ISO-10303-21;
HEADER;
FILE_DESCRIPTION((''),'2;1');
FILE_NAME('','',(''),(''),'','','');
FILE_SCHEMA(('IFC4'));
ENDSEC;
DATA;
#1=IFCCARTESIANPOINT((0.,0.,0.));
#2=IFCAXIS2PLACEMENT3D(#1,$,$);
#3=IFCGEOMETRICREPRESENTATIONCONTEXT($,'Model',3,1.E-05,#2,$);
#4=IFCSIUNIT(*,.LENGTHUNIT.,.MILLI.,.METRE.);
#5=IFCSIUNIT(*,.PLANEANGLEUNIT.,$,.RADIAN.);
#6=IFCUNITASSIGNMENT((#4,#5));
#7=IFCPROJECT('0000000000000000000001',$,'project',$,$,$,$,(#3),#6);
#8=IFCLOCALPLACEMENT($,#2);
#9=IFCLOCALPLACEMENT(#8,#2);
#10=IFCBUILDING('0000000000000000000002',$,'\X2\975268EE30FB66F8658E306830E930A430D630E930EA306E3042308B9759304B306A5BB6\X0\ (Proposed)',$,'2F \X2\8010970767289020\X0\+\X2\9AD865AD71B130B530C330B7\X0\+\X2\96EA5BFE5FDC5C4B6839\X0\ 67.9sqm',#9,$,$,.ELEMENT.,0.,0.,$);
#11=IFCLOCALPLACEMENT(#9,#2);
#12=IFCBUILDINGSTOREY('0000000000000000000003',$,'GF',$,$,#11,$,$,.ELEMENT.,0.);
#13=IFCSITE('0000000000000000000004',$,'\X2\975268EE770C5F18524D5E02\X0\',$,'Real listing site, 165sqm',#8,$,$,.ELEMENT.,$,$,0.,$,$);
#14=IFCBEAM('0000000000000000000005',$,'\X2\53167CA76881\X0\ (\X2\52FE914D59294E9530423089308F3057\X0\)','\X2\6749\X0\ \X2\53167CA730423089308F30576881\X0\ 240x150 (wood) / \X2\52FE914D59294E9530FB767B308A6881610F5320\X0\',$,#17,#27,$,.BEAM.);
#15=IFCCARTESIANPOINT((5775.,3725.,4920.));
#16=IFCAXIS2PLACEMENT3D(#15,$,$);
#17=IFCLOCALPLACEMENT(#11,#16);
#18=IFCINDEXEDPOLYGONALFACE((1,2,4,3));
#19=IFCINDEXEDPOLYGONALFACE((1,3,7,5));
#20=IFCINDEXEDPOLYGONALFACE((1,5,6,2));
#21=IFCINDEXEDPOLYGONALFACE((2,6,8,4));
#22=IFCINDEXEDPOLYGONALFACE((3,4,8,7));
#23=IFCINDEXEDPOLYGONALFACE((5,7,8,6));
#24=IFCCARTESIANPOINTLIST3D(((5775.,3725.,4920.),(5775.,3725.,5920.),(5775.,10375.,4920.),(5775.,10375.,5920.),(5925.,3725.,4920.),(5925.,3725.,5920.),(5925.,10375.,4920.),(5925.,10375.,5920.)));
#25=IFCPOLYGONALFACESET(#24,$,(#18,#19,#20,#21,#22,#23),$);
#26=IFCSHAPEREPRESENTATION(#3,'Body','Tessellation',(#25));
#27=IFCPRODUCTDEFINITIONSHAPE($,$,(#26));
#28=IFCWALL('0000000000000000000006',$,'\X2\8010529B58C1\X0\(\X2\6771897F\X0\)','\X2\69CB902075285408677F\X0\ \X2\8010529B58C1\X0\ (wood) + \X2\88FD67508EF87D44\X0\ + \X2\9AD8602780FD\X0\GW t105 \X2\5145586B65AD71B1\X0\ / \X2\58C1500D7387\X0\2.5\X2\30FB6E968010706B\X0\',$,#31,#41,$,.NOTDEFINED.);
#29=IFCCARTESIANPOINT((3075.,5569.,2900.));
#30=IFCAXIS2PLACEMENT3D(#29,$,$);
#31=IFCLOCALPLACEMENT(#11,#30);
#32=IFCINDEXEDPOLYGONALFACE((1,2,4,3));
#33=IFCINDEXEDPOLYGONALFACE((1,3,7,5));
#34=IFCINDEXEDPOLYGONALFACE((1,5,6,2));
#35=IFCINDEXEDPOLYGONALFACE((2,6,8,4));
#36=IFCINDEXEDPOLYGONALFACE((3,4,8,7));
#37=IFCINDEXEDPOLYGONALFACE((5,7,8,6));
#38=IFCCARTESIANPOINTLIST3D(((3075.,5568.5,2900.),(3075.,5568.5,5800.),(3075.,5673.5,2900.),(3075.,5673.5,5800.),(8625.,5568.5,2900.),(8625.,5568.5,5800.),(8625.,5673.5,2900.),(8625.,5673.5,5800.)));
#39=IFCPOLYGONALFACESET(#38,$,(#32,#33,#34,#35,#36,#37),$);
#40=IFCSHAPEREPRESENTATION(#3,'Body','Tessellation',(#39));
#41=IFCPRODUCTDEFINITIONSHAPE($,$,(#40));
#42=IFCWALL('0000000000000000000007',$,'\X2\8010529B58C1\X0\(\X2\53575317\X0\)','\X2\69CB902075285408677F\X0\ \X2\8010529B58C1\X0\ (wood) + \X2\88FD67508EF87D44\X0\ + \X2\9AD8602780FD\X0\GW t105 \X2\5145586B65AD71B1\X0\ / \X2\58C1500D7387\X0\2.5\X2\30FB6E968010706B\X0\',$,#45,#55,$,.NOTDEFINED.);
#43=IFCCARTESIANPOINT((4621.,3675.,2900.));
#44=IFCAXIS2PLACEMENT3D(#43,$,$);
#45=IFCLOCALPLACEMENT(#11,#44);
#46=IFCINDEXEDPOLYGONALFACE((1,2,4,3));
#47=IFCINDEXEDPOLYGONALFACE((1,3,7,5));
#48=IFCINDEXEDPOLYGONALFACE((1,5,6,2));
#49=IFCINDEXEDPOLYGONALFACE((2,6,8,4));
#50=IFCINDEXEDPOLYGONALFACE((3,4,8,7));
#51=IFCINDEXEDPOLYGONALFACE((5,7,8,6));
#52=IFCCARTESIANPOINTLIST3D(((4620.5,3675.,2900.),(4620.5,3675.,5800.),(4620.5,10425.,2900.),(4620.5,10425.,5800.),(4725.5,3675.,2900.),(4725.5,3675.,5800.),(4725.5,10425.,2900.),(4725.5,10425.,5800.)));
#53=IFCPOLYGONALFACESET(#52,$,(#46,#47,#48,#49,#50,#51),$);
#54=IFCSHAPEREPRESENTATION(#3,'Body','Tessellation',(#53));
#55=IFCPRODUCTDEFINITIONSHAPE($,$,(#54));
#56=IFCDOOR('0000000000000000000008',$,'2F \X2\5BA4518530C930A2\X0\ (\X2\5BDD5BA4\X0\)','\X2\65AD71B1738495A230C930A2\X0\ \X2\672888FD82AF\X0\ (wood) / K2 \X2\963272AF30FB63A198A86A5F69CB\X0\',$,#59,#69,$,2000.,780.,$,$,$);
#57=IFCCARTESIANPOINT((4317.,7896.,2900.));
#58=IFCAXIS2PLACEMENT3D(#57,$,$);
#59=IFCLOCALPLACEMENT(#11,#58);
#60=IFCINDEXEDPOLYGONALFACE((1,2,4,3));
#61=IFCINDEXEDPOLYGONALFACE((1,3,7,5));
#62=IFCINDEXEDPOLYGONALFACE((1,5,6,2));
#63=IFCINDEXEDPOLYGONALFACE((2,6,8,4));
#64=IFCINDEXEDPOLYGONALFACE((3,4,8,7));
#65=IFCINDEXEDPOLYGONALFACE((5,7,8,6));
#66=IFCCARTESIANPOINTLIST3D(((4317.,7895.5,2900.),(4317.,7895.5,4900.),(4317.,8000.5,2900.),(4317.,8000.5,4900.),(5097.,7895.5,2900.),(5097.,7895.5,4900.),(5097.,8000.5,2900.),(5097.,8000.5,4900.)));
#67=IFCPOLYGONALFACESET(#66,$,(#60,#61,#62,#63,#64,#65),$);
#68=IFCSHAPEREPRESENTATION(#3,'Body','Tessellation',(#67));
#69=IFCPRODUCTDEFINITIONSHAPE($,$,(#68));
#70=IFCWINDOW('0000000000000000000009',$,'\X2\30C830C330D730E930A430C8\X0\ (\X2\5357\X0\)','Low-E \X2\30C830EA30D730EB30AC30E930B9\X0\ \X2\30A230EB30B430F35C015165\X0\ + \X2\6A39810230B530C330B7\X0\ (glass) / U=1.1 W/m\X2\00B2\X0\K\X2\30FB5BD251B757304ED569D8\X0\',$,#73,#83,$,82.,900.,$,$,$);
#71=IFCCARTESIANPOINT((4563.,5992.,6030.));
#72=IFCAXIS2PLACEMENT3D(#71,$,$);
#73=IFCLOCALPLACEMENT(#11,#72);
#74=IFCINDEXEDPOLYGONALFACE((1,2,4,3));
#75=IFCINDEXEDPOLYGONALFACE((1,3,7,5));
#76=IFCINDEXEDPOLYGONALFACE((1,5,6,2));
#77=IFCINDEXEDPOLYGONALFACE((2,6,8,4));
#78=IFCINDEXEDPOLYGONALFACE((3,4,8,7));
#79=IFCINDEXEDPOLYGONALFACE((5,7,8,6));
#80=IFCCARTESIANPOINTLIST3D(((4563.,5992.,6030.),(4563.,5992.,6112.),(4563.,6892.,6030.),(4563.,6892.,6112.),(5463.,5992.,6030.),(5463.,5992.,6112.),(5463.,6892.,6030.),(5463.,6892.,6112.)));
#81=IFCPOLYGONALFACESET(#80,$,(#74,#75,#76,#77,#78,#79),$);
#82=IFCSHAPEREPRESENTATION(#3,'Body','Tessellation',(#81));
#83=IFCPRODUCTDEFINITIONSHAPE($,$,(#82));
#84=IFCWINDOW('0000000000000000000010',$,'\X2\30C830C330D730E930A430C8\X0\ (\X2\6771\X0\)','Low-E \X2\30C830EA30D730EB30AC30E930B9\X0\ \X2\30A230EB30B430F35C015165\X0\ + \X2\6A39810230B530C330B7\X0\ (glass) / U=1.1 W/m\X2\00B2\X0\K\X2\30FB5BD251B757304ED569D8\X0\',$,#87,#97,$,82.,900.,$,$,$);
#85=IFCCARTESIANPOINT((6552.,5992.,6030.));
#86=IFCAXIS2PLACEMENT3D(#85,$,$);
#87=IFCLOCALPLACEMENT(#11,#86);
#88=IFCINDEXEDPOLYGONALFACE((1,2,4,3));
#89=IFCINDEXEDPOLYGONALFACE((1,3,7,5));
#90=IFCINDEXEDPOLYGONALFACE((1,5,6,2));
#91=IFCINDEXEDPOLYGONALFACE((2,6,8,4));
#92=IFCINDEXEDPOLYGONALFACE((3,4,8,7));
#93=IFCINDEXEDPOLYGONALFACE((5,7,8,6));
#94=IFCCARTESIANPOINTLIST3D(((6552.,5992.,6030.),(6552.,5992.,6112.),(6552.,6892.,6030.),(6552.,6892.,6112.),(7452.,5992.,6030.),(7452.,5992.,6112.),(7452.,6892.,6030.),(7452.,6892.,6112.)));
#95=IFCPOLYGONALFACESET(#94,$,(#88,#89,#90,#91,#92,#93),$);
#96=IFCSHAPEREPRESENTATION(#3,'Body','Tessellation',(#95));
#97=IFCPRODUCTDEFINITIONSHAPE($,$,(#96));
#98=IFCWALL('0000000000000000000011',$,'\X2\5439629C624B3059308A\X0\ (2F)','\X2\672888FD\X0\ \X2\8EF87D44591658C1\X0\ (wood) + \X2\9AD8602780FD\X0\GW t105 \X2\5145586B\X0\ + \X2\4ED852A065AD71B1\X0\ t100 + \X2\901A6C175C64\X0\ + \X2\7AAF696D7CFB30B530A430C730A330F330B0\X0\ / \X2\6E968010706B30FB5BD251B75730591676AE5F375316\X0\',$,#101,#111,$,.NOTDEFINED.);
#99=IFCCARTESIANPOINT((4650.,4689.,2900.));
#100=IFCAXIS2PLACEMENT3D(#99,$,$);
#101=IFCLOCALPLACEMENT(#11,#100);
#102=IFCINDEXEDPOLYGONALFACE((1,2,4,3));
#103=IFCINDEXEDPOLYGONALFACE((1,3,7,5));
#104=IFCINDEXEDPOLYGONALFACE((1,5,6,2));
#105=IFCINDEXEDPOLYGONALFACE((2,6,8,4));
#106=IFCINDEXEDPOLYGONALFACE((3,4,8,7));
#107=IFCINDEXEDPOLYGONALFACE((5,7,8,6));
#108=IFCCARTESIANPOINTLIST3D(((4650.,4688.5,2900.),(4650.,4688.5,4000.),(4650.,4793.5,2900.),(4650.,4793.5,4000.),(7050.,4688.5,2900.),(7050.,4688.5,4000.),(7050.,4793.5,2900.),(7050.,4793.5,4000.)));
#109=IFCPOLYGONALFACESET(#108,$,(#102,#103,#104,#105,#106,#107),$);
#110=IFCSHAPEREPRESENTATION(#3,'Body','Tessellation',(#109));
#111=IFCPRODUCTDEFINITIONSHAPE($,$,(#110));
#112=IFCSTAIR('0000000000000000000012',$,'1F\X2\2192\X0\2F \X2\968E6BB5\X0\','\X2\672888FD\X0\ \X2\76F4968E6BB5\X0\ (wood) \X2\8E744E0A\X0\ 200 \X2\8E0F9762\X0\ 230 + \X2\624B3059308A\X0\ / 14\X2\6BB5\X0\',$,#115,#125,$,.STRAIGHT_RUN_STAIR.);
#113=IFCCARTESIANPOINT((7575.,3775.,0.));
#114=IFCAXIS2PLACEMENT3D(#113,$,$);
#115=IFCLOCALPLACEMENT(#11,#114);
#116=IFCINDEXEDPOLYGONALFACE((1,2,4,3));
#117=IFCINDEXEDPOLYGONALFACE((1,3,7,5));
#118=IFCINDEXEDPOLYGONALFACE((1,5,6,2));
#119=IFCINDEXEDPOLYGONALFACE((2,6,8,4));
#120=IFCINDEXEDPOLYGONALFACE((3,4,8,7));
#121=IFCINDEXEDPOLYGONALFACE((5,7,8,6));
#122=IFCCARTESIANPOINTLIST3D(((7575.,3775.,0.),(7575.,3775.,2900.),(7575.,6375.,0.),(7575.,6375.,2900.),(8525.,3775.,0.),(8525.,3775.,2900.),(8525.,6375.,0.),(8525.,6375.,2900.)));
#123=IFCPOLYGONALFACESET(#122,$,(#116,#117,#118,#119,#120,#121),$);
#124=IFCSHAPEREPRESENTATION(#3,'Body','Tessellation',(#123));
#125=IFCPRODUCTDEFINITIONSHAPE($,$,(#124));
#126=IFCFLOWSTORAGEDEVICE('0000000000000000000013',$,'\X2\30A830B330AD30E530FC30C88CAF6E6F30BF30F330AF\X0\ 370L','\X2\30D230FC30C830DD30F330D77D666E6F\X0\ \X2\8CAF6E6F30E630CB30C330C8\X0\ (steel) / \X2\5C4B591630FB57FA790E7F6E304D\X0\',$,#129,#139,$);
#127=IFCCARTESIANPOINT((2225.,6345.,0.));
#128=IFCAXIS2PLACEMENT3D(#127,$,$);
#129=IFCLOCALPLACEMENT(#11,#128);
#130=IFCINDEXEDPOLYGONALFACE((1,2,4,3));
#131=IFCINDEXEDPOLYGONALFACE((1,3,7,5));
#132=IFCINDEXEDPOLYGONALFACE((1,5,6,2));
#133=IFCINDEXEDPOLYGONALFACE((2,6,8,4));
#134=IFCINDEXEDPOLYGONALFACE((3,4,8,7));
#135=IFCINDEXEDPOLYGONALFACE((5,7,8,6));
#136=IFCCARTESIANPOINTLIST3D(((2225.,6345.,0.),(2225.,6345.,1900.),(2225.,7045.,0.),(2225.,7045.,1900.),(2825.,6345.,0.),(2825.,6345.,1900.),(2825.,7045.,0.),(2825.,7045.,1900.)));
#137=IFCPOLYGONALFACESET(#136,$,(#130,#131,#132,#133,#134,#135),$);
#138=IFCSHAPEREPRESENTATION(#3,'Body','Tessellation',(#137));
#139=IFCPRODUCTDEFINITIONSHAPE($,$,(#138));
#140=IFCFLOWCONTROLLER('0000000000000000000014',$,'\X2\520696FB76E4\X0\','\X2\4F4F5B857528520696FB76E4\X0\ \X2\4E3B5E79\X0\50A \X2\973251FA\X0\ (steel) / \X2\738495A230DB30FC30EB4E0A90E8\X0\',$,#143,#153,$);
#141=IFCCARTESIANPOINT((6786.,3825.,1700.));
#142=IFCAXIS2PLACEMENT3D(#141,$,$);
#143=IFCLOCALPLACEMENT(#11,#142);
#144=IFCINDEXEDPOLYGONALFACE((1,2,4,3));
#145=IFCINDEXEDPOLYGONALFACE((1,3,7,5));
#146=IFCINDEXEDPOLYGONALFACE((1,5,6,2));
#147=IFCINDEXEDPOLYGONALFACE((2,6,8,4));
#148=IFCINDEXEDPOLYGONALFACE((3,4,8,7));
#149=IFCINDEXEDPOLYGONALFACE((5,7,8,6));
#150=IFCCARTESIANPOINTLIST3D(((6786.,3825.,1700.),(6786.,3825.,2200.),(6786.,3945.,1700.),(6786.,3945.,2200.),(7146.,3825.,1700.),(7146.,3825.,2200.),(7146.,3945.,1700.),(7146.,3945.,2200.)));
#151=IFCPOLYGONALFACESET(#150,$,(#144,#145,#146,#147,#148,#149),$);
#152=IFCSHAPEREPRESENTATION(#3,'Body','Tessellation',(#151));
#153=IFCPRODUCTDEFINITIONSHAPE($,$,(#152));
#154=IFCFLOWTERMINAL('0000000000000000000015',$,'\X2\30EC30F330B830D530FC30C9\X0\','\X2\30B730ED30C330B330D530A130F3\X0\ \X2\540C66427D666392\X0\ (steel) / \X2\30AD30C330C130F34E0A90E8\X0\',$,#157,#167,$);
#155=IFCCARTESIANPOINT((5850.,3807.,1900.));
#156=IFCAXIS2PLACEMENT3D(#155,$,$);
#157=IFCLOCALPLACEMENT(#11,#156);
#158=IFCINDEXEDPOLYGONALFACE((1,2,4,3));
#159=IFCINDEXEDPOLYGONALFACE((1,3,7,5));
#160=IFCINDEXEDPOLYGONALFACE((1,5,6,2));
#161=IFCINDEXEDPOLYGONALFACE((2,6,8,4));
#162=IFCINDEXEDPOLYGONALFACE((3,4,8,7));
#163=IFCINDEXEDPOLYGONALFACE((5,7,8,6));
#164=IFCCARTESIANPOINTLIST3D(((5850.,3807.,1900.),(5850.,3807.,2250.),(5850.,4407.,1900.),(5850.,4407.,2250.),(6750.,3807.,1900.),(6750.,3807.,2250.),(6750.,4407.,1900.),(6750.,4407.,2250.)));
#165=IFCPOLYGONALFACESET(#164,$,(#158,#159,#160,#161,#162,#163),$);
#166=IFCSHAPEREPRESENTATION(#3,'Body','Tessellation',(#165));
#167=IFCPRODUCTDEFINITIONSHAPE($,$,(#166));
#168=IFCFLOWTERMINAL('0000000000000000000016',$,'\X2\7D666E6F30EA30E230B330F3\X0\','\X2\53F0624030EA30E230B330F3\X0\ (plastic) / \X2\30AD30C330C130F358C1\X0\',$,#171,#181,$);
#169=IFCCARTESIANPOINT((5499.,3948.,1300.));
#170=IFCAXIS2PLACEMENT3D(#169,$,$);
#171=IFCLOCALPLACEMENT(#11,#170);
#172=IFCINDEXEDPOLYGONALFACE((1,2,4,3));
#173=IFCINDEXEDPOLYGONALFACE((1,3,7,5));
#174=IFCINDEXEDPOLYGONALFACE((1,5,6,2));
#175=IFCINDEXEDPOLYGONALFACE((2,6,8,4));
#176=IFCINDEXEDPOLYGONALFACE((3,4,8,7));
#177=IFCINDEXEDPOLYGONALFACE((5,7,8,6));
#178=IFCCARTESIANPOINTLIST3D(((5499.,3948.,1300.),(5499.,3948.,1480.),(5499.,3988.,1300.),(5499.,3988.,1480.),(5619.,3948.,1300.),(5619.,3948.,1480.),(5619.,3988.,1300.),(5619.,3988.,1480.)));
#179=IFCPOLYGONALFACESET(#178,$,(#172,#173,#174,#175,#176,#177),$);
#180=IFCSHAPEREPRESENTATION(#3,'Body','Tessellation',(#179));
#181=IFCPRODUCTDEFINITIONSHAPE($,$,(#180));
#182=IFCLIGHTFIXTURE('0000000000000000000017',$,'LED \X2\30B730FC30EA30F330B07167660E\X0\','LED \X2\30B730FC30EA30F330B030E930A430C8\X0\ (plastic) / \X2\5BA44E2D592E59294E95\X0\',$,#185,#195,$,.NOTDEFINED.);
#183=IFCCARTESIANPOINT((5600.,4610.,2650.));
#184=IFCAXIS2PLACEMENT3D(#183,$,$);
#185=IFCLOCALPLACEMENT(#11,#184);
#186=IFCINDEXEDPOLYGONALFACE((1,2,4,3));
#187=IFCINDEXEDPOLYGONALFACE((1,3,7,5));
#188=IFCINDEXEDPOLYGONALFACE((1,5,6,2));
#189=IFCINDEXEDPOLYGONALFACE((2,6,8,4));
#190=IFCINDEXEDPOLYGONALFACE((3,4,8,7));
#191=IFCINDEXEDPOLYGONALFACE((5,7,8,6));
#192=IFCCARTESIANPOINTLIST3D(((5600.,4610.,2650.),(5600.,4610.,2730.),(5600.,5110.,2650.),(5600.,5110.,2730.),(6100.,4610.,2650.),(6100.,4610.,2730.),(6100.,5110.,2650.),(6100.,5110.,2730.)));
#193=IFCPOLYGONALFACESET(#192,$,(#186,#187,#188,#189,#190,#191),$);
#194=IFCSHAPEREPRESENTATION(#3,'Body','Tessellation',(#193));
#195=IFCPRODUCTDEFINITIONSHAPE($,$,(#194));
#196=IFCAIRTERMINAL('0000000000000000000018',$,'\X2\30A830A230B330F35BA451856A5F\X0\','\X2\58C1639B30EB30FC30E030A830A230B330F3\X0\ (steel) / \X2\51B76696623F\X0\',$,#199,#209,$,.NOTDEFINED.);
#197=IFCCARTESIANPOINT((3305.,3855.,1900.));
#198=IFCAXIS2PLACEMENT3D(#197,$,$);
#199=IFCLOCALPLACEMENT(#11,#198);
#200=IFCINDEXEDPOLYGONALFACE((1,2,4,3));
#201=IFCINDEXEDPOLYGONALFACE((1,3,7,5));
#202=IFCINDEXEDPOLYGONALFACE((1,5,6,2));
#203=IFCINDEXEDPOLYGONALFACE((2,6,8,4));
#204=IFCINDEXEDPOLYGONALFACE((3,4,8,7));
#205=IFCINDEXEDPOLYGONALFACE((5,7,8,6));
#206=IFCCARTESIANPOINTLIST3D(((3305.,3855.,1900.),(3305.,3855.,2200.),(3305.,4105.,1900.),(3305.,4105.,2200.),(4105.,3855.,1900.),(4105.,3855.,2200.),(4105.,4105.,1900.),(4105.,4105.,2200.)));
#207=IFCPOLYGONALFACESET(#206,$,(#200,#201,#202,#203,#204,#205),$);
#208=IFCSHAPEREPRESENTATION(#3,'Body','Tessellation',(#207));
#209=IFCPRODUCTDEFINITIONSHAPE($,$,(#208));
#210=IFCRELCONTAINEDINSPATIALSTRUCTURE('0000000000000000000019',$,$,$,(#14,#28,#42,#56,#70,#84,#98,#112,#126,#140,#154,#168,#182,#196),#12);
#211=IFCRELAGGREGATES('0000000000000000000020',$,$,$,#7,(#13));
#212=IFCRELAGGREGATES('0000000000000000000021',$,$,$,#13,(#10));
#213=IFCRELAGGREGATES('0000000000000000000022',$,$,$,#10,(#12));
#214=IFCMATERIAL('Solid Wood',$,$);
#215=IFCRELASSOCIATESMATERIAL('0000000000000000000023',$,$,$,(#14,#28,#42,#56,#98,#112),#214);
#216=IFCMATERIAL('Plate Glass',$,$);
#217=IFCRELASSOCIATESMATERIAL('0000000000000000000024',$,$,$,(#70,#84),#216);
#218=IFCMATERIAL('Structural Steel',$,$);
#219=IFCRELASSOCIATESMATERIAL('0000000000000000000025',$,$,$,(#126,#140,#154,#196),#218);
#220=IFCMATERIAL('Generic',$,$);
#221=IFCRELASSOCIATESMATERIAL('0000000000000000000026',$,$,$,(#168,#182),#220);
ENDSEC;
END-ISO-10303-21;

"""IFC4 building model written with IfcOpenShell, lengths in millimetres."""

from ifc_helpers import new_model, si_unit, frame, frame_2d, origin, place, context, project, spatial, rectangle, extrude, material, element, fill, save


model = new_model("IFC4")

# Units and contexts
model_context = context("Model", 3, precision=1e-05, world=origin())
ifc_project = project(units=[si_unit("LENGTHUNIT", "METRE", prefix="MILLI"), si_unit("PLANEANGLEUNIT", "RADIAN")], contexts=[model_context])

# Site, building, storey
site_placement = place(None, origin())
site = spatial("IfcSite", under=ifc_project, at=site_placement, Name="青森県弘前市", ObjectType="Real listing site, 165sqm", CompositionType="ELEMENT", RefElevation=0.0)
building_placement = place(site_placement, origin())
building = spatial("IfcBuilding", under=site, at=building_placement, Name="青森・書斎とライブラリのある静かな家 (Proposed)", ObjectType="2F 耐震木造+高断熱サッシ+雪対応屋根 67.9sqm", CompositionType="ELEMENT", ElevationOfRefHeight=0.0, ElevationOfTerrain=0.0)
storey_placement = place(building_placement, origin())
storey = spatial("IfcBuildingStorey", under=building, at=storey_placement, Name="GF", CompositionType="ELEMENT", Elevation=0.0)

# Shared definitions
ifc_material_1 = material(Name="Solid Wood")

# Beam
beam_placement = place(storey_placement, frame((5775.0, 3725.0, 4920.0)))
element("IfcBeam", 1, at=beam_placement, inside=storey, material=ifc_material_1, Name="化粧梁 (勾配天井あらわし)", Description="杉 化粧あらわし梁 240x150 (wood) / 勾配天井・登り梁意匠", PredefinedType="BEAM", context=model_context, shape_type="SweptSolid", body=[
    extrude(rectangle(XDim=150.0, YDim=6650.0, at=frame_2d((75.0, 3325.0))), frame((5775.0, 3725.0, 4920.0)), (0.0, 0.0, 1.0), 1000.0),
])

# Wall
wall_1_placement = place(storey_placement, frame((3075.0, 5569.0, 2900.0)))
element("IfcWall", 2, at=wall_1_placement, inside=storey, material=ifc_material_1, Name="耐力壁(東西)", Description="構造用合板 耐力壁 (wood) + 製材軸組 + 高性能GW t105 充填断熱 / 壁倍率2.5・準耐火", PredefinedType="NOTDEFINED", context=model_context, shape_type="SweptSolid", body=[
    extrude(rectangle(XDim=5550.0, YDim=105.0, at=frame_2d((2775.0, 52.0))), frame((3075.0, 5569.0, 2900.0)), (0.0, 0.0, 1.0), 2900.0),
])

# Wall, opening, door
wall_2_placement = place(storey_placement, frame((4621.0, 3675.0, 2900.0)))
wall_2 = element("IfcWall", 3, at=wall_2_placement, inside=storey, material=ifc_material_1, Name="耐力壁(南北)", Description="構造用合板 耐力壁 (wood) + 製材軸組 + 高性能GW t105 充填断熱 / 壁倍率2.5・準耐火", PredefinedType="NOTDEFINED", context=model_context, shape_type="SweptSolid", body=[
    extrude(rectangle(XDim=105.0, YDim=6750.0, at=frame_2d((52.0, 3375.0))), frame((4621.0, 3675.0, 2900.0)), (0.0, 0.0, 1.0), 2900.0),
])
opening_placement = place(storey_placement, frame((4317.0, 7896.0, 2900.0)))
opening = element("IfcOpeningElement", 4, at=opening_placement, cuts=wall_2, PredefinedType="NOTDEFINED", context=model_context, shape_type="SweptSolid", body=[
    extrude(rectangle(XDim=780.0, YDim=105.0, at=frame_2d((390.0, 52.0))), frame((4317.0, 7896.0, 2900.0)), (0.0, 0.0, 1.0), 2000.0),
])
door_placement = place(storey_placement, frame((4317.0, 7896.0, 2900.0)))
door = element("IfcDoor", 5, at=door_placement, inside=storey, material=ifc_material_1, Name="2F 室内ドア (寝室)", Description="断熱玄関ドア 木製芯 (wood) / K2 防犯・採風機構", OverallHeight=2000.0, OverallWidth=780.0, context=model_context, shape_type="SweptSolid", body=[
    extrude(rectangle(XDim=780.0, YDim=105.0, at=frame_2d((390.0, 52.0))), frame((4317.0, 7896.0, 2900.0)), (0.0, 0.0, 1.0), 2000.0),
])
fill(opening, door)

# Windows
ifc_material_2 = material(Name="Plate Glass")
window_1_placement = place(storey_placement, frame((4563.0, 5992.0, 6030.0)))
element("IfcWindow", 6, at=window_1_placement, inside=storey, material=ifc_material_2, Name="トップライト (南)", Description="Low-E トリプルガラス アルゴン封入 + 樹脂サッシ (glass) / U=1.1 W/m²K・寒冷地仕様", OverallHeight=82.0, OverallWidth=900.0, context=model_context, shape_type="SweptSolid", body=[
    extrude(rectangle(XDim=900.0, YDim=900.0, at=frame_2d((450.0, 450.0))), frame((4563.0, 5992.0, 6030.0)), (0.0, 0.0, 1.0), 82.0),
])
window_2_placement = place(storey_placement, frame((6552.0, 5992.0, 6030.0)))
element("IfcWindow", 7, at=window_2_placement, inside=storey, material=ifc_material_2, Name="トップライト (東)", Description="Low-E トリプルガラス アルゴン封入 + 樹脂サッシ (glass) / U=1.1 W/m²K・寒冷地仕様", OverallHeight=82.0, OverallWidth=900.0, context=model_context, shape_type="SweptSolid", body=[
    extrude(rectangle(XDim=900.0, YDim=900.0, at=frame_2d((450.0, 450.0))), frame((6552.0, 5992.0, 6030.0)), (0.0, 0.0, 1.0), 82.0),
])

# Wall
wall_3_placement = place(storey_placement, frame((4650.0, 4689.0, 2900.0)))
element("IfcWall", 8, at=wall_3_placement, inside=storey, material=ifc_material_1, Name="吹抜手すり (2F)", Description="木製 軸組外壁 (wood) + 高性能GW t105 充填 + 付加断熱 t100 + 通気層 + 窯業系サイディング / 準耐火・寒冷地外皮強化", PredefinedType="NOTDEFINED", context=model_context, shape_type="SweptSolid", body=[
    extrude(rectangle(XDim=2400.0, YDim=105.0, at=frame_2d((1200.0, 52.0))), frame((4650.0, 4689.0, 2900.0)), (0.0, 0.0, 1.0), 1100.0),
])

# Stair
stair_placement = place(storey_placement, frame((7575.0, 3775.0, 0.0)))
element("IfcStair", 9, at=stair_placement, inside=storey, material=ifc_material_1, Name="1F→2F 階段", Description="木製 直階段 (wood) 蹴上 200 踏面 230 + 手すり / 14段", PredefinedType="STRAIGHT_RUN_STAIR", context=model_context, shape_type="SweptSolid", body=[
    extrude(rectangle(XDim=950.0, YDim=2600.0, at=frame_2d((475.0, 1300.0))), frame((7575.0, 3775.0, 0.0)), (0.0, 0.0, 1.0), 2900.0),
])

# Flow storage device
ifc_material_3 = material(Name="Structural Steel")
flow_storage_device_placement = place(storey_placement, frame((2225.0, 6345.0, 0.0)))
element("IfcFlowStorageDevice", 10, at=flow_storage_device_placement, inside=storey, material=ifc_material_3, Name="エコキュート貯湯タンク 370L", Description="ヒートポンプ給湯 貯湯ユニット (steel) / 屋外・基礎置き", context=model_context, shape_type="SweptSolid", body=[
    extrude(rectangle(XDim=600.0, YDim=700.0, at=frame_2d((300.0, 350.0))), frame((2225.0, 6345.0, 0.0)), (0.0, 0.0, 1.0), 1900.0),
])

# Flow controller
flow_controller_placement = place(storey_placement, frame((6786.0, 3825.0, 1700.0)))
element("IfcFlowController", 11, at=flow_controller_placement, inside=storey, material=ifc_material_3, Name="分電盤", Description="住宅用分電盤 主幹50A 露出 (steel) / 玄関ホール上部", context=model_context, shape_type="SweptSolid", body=[
    extrude(rectangle(XDim=360.0, YDim=120.0, at=frame_2d((180.0, 60.0))), frame((6786.0, 3825.0, 1700.0)), (0.0, 0.0, 1.0), 500.0),
])

# Flow terminals
flow_terminal_1_placement = place(storey_placement, frame((5850.0, 3807.0, 1900.0)))
element("IfcFlowTerminal", 12, at=flow_terminal_1_placement, inside=storey, material=ifc_material_3, Name="レンジフード", Description="シロッコファン 同時給排 (steel) / キッチン上部", context=model_context, shape_type="SweptSolid", body=[
    extrude(rectangle(XDim=900.0, YDim=600.0, at=frame_2d((450.0, 300.0))), frame((5850.0, 3807.0, 1900.0)), (0.0, 0.0, 1.0), 350.0),
])
ifc_material_4 = material(Name="Generic")
flow_terminal_2_placement = place(storey_placement, frame((5499.0, 3948.0, 1300.0)))
element("IfcFlowTerminal", 13, at=flow_terminal_2_placement, inside=storey, material=ifc_material_4, Name="給湯リモコン", Description="台所リモコン (plastic) / キッチン壁", context=model_context, shape_type="SweptSolid", body=[
    extrude(rectangle(XDim=120.0, YDim=40.0, at=frame_2d((60.0, 20.0))), frame((5499.0, 3948.0, 1300.0)), (0.0, 0.0, 1.0), 180.0),
])

# Light fixture
light_fixture_1_placement = place(storey_placement, frame((5600.0, 4610.0, 2650.0)))
element("IfcLightFixture", 14, at=light_fixture_1_placement, inside=storey, material=ifc_material_4, Name="LED シーリング照明", Description="LED シーリングライト (plastic) / 室中央天井", PredefinedType="NOTDEFINED", context=model_context, shape_type="SweptSolid", body=[
    extrude(rectangle(XDim=500.0, YDim=500.0, at=frame_2d((250.0, 250.0))), frame((5600.0, 4610.0, 2650.0)), (0.0, 0.0, 1.0), 80.0),
])

# Air terminal
air_terminal_1_placement = place(storey_placement, frame((3305.0, 3855.0, 1900.0)))
element("IfcAirTerminal", 15, at=air_terminal_1_placement, inside=storey, material=ifc_material_3, Name="エアコン室内機", Description="壁掛ルームエアコン (steel) / 冷暖房", PredefinedType="NOTDEFINED", context=model_context, shape_type="SweptSolid", body=[
    extrude(rectangle(XDim=800.0, YDim=250.0, at=frame_2d((400.0, 125.0))), frame((3305.0, 3855.0, 1900.0)), (0.0, 0.0, 1.0), 300.0),
])

save(model, "model.ifc")
